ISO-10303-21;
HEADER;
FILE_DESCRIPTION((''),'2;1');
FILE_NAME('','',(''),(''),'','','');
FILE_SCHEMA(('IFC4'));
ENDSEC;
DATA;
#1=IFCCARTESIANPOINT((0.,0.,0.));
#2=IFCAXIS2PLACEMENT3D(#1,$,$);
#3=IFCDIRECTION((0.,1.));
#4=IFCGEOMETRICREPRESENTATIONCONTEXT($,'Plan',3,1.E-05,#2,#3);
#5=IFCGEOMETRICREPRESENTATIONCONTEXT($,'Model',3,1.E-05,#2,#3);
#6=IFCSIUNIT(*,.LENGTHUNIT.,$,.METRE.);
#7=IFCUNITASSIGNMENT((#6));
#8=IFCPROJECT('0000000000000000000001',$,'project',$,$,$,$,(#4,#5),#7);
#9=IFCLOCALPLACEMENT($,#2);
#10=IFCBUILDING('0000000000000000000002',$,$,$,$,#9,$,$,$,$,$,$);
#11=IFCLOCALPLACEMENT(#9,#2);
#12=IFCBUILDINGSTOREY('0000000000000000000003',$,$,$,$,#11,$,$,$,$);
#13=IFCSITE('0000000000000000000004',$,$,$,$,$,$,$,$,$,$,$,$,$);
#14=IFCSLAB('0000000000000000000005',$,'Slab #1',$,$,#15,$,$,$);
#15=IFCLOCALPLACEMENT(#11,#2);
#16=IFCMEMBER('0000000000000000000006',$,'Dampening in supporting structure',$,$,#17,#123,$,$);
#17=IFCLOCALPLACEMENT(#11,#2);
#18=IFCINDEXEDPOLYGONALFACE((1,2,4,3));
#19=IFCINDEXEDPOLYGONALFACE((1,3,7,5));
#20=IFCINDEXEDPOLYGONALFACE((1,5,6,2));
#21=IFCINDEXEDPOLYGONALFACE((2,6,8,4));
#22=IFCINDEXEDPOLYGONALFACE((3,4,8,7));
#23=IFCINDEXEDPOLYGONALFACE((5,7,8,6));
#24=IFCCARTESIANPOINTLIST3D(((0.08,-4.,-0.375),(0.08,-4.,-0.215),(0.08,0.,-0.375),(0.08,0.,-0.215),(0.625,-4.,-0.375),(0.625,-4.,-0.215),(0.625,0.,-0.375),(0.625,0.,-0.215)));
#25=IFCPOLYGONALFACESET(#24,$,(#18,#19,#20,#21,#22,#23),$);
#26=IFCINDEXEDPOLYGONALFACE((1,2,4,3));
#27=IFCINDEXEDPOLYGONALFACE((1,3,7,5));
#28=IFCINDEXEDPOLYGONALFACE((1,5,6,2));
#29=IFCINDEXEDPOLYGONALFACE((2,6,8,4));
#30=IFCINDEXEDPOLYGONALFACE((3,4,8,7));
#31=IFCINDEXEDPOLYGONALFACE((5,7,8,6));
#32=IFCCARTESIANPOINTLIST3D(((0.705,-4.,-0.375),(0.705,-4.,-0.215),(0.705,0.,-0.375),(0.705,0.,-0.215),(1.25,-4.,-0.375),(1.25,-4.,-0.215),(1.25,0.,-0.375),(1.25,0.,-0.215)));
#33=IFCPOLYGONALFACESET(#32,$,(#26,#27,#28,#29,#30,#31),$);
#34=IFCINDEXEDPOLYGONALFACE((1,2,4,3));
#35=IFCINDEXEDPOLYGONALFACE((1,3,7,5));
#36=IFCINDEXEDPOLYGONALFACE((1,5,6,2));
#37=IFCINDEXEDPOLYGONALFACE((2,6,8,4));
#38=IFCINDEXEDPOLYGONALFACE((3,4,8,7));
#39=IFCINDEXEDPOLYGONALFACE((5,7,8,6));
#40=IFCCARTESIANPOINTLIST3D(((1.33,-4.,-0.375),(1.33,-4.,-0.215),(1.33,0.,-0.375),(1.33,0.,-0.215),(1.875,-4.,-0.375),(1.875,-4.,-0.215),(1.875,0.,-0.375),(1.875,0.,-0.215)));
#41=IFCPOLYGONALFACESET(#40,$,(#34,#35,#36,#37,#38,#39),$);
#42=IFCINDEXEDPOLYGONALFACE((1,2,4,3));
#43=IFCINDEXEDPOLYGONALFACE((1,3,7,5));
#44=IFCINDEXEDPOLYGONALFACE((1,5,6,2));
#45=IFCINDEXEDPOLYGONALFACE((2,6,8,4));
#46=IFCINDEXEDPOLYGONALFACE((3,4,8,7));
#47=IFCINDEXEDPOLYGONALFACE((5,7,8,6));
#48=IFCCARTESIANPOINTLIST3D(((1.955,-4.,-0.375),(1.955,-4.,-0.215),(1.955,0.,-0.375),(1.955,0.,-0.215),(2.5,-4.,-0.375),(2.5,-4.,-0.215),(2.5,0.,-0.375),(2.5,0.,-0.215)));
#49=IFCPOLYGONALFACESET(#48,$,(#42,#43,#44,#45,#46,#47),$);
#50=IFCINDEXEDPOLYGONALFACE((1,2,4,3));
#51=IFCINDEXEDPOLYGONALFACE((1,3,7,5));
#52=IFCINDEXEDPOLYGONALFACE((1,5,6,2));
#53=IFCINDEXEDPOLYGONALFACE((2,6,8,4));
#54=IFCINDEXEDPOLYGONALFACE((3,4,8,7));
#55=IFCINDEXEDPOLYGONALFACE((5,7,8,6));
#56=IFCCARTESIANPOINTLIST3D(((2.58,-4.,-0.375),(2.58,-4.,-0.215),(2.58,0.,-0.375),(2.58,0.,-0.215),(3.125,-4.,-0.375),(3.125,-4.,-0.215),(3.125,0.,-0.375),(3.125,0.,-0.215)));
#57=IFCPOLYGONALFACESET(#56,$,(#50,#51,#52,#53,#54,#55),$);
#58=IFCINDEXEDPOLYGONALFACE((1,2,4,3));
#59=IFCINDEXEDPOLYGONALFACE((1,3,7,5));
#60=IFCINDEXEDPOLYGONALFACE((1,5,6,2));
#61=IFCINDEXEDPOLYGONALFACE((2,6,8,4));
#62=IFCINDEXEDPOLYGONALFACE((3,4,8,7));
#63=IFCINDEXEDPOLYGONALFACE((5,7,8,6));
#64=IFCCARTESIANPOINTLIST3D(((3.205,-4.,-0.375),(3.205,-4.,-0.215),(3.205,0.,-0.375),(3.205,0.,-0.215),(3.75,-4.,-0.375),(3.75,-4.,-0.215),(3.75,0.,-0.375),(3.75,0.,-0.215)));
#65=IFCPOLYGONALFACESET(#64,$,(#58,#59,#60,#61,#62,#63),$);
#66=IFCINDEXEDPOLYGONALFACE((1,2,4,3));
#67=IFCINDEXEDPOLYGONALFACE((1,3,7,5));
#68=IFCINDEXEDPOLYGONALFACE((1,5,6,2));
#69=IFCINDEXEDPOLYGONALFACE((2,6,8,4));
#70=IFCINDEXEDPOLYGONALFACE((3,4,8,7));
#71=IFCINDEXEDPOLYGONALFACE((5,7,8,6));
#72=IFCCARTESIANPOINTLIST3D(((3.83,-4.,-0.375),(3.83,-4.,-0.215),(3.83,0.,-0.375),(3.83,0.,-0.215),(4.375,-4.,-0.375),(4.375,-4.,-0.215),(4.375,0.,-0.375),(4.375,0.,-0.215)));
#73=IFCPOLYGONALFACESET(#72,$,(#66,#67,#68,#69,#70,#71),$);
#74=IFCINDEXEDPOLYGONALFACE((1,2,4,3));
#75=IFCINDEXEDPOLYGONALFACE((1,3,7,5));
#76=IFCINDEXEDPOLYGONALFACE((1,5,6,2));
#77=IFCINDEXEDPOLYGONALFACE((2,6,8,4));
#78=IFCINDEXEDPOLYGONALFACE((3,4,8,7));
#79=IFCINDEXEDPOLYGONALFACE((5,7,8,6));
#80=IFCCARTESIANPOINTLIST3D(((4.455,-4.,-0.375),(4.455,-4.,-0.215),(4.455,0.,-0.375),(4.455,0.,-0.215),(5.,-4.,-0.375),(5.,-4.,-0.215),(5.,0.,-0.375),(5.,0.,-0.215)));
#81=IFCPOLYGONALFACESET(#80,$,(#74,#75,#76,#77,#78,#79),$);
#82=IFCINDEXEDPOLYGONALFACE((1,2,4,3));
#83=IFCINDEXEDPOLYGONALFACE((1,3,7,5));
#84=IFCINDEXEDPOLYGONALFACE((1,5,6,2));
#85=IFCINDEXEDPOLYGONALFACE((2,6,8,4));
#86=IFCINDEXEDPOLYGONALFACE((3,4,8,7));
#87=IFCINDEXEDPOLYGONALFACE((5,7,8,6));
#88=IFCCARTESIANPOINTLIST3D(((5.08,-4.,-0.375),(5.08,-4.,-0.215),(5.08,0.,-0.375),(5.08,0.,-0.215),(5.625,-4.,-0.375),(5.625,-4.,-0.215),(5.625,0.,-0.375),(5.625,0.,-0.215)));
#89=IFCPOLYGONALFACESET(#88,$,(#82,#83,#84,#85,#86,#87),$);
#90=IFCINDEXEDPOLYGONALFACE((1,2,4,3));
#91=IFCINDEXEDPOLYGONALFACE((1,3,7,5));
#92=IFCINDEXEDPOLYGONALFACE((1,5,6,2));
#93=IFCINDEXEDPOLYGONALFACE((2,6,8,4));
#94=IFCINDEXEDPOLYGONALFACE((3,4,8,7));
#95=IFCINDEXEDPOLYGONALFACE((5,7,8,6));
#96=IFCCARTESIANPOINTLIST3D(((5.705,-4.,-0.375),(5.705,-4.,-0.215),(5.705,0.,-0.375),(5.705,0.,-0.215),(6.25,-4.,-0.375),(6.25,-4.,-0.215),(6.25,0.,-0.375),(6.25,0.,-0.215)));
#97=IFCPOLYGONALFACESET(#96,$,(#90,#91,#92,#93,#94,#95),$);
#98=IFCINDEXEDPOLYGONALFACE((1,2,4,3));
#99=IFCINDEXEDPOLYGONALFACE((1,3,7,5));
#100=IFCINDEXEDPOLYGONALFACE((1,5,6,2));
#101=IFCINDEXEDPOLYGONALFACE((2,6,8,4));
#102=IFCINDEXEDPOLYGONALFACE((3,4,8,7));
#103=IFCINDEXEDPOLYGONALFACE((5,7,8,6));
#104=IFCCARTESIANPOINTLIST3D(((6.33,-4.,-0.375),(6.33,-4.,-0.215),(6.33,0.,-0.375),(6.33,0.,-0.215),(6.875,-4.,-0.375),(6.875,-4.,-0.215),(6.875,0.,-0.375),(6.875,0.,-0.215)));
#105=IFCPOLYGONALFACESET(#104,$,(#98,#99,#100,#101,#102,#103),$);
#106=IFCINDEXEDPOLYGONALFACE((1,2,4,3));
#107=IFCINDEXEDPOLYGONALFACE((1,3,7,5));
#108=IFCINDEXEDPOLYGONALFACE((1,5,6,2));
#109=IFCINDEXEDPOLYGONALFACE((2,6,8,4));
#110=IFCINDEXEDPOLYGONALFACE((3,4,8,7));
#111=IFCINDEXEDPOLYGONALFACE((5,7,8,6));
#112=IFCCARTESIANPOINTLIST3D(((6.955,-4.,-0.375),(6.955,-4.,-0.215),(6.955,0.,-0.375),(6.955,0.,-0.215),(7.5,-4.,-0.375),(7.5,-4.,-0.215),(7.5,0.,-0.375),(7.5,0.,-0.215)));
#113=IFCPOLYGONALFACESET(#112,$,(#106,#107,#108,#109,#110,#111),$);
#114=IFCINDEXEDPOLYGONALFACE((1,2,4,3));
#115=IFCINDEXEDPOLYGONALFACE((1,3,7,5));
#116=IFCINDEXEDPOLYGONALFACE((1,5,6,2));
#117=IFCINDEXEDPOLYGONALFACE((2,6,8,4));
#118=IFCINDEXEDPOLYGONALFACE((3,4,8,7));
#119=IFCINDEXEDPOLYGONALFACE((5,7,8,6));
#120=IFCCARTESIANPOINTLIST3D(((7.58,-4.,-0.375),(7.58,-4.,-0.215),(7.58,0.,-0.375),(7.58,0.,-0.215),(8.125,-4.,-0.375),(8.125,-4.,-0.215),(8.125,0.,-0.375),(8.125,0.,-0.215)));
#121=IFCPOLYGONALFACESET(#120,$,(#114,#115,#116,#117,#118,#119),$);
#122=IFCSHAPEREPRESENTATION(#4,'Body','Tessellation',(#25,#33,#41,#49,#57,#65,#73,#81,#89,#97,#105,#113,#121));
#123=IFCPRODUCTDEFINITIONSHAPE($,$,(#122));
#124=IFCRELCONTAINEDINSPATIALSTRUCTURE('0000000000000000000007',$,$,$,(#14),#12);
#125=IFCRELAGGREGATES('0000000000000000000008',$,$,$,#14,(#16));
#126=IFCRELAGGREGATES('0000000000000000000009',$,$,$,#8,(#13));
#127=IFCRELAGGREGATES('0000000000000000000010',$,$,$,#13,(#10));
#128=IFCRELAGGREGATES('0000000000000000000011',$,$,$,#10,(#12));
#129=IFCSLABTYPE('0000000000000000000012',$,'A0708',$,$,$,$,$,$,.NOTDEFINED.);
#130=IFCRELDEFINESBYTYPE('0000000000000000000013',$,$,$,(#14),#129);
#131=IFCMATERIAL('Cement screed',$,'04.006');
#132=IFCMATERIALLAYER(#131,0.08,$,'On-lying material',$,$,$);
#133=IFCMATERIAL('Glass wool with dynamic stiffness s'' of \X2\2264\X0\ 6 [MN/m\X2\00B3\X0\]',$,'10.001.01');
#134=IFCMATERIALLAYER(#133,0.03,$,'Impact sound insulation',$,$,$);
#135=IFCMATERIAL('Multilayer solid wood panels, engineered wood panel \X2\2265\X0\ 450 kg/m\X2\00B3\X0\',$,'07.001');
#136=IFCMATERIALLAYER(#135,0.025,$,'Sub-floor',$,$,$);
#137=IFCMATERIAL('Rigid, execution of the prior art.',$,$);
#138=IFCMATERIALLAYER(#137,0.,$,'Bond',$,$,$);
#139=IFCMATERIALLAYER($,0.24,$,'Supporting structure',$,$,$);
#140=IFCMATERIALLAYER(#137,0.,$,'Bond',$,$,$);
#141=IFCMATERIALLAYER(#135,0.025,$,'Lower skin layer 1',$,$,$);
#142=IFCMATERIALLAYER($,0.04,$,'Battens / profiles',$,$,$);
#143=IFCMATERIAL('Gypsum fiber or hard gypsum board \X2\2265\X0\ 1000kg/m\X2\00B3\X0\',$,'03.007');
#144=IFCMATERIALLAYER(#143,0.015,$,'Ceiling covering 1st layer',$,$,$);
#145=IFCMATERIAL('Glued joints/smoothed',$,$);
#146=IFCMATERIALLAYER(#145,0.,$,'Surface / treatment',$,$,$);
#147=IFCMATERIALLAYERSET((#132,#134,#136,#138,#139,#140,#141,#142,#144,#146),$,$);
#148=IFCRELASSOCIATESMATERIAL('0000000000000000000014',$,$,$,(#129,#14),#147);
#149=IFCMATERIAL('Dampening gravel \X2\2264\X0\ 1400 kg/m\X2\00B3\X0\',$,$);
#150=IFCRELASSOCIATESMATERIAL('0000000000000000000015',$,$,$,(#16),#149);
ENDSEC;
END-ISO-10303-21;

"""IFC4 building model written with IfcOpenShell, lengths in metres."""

from ifc_helpers import new_model, si_unit, direction, frame, frame_2d, origin, place, context, project, spatial, rectangle, extrude, material, layer, layer_set, type_object, element, aggregate, save


model = new_model("IFC4")

# Units and contexts
plan_context = context("Plan", 3, precision=1e-05, world=origin(), true_north=direction((0.0, 1.0)))
model_context = context("Model", 3, precision=1e-05, world=origin(), true_north=direction((0.0, 1.0)))
ifc_project = project(units=[si_unit("LENGTHUNIT", "METRE")], contexts=[plan_context, model_context])

# Site, building, storey
site = spatial("IfcSite", under=ifc_project)
building_placement = place(None, origin())
building = spatial("IfcBuilding", under=site, at=building_placement)
storey_placement = place(building_placement, origin())
storey = spatial("IfcBuildingStorey", under=building, at=storey_placement)

# Slab, member
ifc_material_1 = material(Name="Cement screed", Category="04.006")
ifc_layer_1 = layer(ifc_material_1, 0.08, Name="On-lying material")
ifc_material_2 = material(Name="Glass wool with dynamic stiffness s' of ≤ 6 [MN/m³]", Category="10.001.01")
ifc_layer_2 = layer(ifc_material_2, 0.03, Name="Impact sound insulation")
ifc_material_3 = material(Name="Multilayer solid wood panels, engineered wood panel ≥ 450 kg/m³", Category="07.001")
ifc_layer_3 = layer(ifc_material_3, 0.025, Name="Sub-floor")
ifc_material_4 = material(Name="Rigid, execution of the prior art.")
ifc_layer_4 = layer(ifc_material_4, 0.0, Name="Bond")
ifc_layer_5 = layer(None, 0.24, Name="Supporting structure")
ifc_layer_6 = layer(ifc_material_4, 0.0, Name="Bond")
ifc_layer_7 = layer(ifc_material_3, 0.025, Name="Lower skin layer 1")
ifc_layer_8 = layer(None, 0.04, Name="Battens / profiles")
ifc_material_5 = material(Name="Gypsum fiber or hard gypsum board ≥ 1000kg/m³", Category="03.007")
ifc_layer_9 = layer(ifc_material_5, 0.015, Name="Ceiling covering 1st layer")
ifc_material_6 = material(Name="Glued joints/smoothed")
ifc_layer_10 = layer(ifc_material_6, 0.0, Name="Surface / treatment")
ifc_layer_set = layer_set([ifc_layer_1, ifc_layer_2, ifc_layer_3, ifc_layer_4, ifc_layer_5, ifc_layer_6, ifc_layer_7, ifc_layer_8, ifc_layer_9, ifc_layer_10])
slab_type = type_object("IfcSlabType", Name="A0708", PredefinedType="NOTDEFINED", material=ifc_layer_set)
slab_placement = place(None, frame((0.0, 0.0, 0.0), z_axis=(0.0, 0.0, -1.0), x_axis=(1.0, 0.0, 0.0)))
slab = element("IfcSlab", 1, at=slab_placement, inside=storey, type_object=slab_type, material=ifc_layer_set, Name="Slab #1")
ifc_material_7 = material(Name="Dampening gravel ≤ 1400 kg/m³")
member_1_placement = place(slab_placement, origin())
member_1 = element("IfcMember", 2, at=member_1_placement, material=ifc_material_7, Name="Dampening in supporting structure", context=plan_context, shape_type="SweptSolid", body=[
    extrude(rectangle(XDim=0.545, YDim=0.16, at=frame_2d((0.2725, 0.08), x_axis=(1.0, 0.0))), frame((0.08, 4.0, 0.215), z_axis=(0.0, -1.0, 0.0), x_axis=(1.0, 0.0, 0.0)), (0.0, 0.0, 1.0), 4.0),
    extrude(rectangle(XDim=0.545, YDim=0.16, at=frame_2d((0.2725, 0.08), x_axis=(1.0, 0.0))), frame((0.705, 4.0, 0.215), z_axis=(0.0, -1.0, 0.0), x_axis=(1.0, 0.0, 0.0)), (0.0, 0.0, 1.0), 4.0),
    extrude(rectangle(XDim=0.545, YDim=0.16, at=frame_2d((0.2725, 0.08), x_axis=(1.0, 0.0))), frame((1.33, 4.0, 0.215), z_axis=(0.0, -1.0, 0.0), x_axis=(1.0, 0.0, 0.0)), (0.0, 0.0, 1.0), 4.0),
    extrude(rectangle(XDim=0.545, YDim=0.16, at=frame_2d((0.2725, 0.08), x_axis=(1.0, 0.0))), frame((1.955, 4.0, 0.215), z_axis=(0.0, -1.0, 0.0), x_axis=(1.0, 0.0, 0.0)), (0.0, 0.0, 1.0), 4.0),
    extrude(rectangle(XDim=0.545, YDim=0.16, at=frame_2d((0.2725, 0.08), x_axis=(1.0, 0.0))), frame((2.58, 4.0, 0.215), z_axis=(0.0, -1.0, 0.0), x_axis=(1.0, 0.0, 0.0)), (0.0, 0.0, 1.0), 4.0),
    extrude(rectangle(XDim=0.545, YDim=0.16, at=frame_2d((0.2725, 0.08), x_axis=(1.0, 0.0))), frame((3.205, 4.0, 0.215), z_axis=(0.0, -1.0, 0.0), x_axis=(1.0, 0.0, 0.0)), (0.0, 0.0, 1.0), 4.0),
    extrude(rectangle(XDim=0.545, YDim=0.16, at=frame_2d((0.2725, 0.08), x_axis=(1.0, 0.0))), frame((3.83, 4.0, 0.215), z_axis=(0.0, -1.0, 0.0), x_axis=(1.0, 0.0, 0.0)), (0.0, 0.0, 1.0), 4.0),
    extrude(rectangle(XDim=0.545, YDim=0.16, at=frame_2d((0.2725, 0.08), x_axis=(1.0, 0.0))), frame((4.455, 4.0, 0.215), z_axis=(0.0, -1.0, 0.0), x_axis=(1.0, 0.0, 0.0)), (0.0, 0.0, 1.0), 4.0),
    extrude(rectangle(XDim=0.545, YDim=0.16, at=frame_2d((0.2725, 0.08), x_axis=(1.0, 0.0))), frame((5.08, 4.0, 0.215), z_axis=(0.0, -1.0, 0.0), x_axis=(1.0, 0.0, 0.0)), (0.0, 0.0, 1.0), 4.0),
    extrude(rectangle(XDim=0.545, YDim=0.16, at=frame_2d((0.2725, 0.08), x_axis=(1.0, 0.0))), frame((5.705, 4.0, 0.215), z_axis=(0.0, -1.0, 0.0), x_axis=(1.0, 0.0, 0.0)), (0.0, 0.0, 1.0), 4.0),
    extrude(rectangle(XDim=0.545, YDim=0.16, at=frame_2d((0.2725, 0.08), x_axis=(1.0, 0.0))), frame((6.33, 4.0, 0.215), z_axis=(0.0, -1.0, 0.0), x_axis=(1.0, 0.0, 0.0)), (0.0, 0.0, 1.0), 4.0),
    extrude(rectangle(XDim=0.545, YDim=0.16, at=frame_2d((0.2725, 0.08), x_axis=(1.0, 0.0))), frame((6.955, 4.0, 0.215), z_axis=(0.0, -1.0, 0.0), x_axis=(1.0, 0.0, 0.0)), (0.0, 0.0, 1.0), 4.0),
    extrude(rectangle(XDim=0.545, YDim=0.16, at=frame_2d((0.2725, 0.08), x_axis=(1.0, 0.0))), frame((7.58, 4.0, 0.215), z_axis=(0.0, -1.0, 0.0), x_axis=(1.0, 0.0, 0.0)), (0.0, 0.0, 1.0), 4.0),
])
aggregate(slab, [member_1])

save(model, "model.ifc")
